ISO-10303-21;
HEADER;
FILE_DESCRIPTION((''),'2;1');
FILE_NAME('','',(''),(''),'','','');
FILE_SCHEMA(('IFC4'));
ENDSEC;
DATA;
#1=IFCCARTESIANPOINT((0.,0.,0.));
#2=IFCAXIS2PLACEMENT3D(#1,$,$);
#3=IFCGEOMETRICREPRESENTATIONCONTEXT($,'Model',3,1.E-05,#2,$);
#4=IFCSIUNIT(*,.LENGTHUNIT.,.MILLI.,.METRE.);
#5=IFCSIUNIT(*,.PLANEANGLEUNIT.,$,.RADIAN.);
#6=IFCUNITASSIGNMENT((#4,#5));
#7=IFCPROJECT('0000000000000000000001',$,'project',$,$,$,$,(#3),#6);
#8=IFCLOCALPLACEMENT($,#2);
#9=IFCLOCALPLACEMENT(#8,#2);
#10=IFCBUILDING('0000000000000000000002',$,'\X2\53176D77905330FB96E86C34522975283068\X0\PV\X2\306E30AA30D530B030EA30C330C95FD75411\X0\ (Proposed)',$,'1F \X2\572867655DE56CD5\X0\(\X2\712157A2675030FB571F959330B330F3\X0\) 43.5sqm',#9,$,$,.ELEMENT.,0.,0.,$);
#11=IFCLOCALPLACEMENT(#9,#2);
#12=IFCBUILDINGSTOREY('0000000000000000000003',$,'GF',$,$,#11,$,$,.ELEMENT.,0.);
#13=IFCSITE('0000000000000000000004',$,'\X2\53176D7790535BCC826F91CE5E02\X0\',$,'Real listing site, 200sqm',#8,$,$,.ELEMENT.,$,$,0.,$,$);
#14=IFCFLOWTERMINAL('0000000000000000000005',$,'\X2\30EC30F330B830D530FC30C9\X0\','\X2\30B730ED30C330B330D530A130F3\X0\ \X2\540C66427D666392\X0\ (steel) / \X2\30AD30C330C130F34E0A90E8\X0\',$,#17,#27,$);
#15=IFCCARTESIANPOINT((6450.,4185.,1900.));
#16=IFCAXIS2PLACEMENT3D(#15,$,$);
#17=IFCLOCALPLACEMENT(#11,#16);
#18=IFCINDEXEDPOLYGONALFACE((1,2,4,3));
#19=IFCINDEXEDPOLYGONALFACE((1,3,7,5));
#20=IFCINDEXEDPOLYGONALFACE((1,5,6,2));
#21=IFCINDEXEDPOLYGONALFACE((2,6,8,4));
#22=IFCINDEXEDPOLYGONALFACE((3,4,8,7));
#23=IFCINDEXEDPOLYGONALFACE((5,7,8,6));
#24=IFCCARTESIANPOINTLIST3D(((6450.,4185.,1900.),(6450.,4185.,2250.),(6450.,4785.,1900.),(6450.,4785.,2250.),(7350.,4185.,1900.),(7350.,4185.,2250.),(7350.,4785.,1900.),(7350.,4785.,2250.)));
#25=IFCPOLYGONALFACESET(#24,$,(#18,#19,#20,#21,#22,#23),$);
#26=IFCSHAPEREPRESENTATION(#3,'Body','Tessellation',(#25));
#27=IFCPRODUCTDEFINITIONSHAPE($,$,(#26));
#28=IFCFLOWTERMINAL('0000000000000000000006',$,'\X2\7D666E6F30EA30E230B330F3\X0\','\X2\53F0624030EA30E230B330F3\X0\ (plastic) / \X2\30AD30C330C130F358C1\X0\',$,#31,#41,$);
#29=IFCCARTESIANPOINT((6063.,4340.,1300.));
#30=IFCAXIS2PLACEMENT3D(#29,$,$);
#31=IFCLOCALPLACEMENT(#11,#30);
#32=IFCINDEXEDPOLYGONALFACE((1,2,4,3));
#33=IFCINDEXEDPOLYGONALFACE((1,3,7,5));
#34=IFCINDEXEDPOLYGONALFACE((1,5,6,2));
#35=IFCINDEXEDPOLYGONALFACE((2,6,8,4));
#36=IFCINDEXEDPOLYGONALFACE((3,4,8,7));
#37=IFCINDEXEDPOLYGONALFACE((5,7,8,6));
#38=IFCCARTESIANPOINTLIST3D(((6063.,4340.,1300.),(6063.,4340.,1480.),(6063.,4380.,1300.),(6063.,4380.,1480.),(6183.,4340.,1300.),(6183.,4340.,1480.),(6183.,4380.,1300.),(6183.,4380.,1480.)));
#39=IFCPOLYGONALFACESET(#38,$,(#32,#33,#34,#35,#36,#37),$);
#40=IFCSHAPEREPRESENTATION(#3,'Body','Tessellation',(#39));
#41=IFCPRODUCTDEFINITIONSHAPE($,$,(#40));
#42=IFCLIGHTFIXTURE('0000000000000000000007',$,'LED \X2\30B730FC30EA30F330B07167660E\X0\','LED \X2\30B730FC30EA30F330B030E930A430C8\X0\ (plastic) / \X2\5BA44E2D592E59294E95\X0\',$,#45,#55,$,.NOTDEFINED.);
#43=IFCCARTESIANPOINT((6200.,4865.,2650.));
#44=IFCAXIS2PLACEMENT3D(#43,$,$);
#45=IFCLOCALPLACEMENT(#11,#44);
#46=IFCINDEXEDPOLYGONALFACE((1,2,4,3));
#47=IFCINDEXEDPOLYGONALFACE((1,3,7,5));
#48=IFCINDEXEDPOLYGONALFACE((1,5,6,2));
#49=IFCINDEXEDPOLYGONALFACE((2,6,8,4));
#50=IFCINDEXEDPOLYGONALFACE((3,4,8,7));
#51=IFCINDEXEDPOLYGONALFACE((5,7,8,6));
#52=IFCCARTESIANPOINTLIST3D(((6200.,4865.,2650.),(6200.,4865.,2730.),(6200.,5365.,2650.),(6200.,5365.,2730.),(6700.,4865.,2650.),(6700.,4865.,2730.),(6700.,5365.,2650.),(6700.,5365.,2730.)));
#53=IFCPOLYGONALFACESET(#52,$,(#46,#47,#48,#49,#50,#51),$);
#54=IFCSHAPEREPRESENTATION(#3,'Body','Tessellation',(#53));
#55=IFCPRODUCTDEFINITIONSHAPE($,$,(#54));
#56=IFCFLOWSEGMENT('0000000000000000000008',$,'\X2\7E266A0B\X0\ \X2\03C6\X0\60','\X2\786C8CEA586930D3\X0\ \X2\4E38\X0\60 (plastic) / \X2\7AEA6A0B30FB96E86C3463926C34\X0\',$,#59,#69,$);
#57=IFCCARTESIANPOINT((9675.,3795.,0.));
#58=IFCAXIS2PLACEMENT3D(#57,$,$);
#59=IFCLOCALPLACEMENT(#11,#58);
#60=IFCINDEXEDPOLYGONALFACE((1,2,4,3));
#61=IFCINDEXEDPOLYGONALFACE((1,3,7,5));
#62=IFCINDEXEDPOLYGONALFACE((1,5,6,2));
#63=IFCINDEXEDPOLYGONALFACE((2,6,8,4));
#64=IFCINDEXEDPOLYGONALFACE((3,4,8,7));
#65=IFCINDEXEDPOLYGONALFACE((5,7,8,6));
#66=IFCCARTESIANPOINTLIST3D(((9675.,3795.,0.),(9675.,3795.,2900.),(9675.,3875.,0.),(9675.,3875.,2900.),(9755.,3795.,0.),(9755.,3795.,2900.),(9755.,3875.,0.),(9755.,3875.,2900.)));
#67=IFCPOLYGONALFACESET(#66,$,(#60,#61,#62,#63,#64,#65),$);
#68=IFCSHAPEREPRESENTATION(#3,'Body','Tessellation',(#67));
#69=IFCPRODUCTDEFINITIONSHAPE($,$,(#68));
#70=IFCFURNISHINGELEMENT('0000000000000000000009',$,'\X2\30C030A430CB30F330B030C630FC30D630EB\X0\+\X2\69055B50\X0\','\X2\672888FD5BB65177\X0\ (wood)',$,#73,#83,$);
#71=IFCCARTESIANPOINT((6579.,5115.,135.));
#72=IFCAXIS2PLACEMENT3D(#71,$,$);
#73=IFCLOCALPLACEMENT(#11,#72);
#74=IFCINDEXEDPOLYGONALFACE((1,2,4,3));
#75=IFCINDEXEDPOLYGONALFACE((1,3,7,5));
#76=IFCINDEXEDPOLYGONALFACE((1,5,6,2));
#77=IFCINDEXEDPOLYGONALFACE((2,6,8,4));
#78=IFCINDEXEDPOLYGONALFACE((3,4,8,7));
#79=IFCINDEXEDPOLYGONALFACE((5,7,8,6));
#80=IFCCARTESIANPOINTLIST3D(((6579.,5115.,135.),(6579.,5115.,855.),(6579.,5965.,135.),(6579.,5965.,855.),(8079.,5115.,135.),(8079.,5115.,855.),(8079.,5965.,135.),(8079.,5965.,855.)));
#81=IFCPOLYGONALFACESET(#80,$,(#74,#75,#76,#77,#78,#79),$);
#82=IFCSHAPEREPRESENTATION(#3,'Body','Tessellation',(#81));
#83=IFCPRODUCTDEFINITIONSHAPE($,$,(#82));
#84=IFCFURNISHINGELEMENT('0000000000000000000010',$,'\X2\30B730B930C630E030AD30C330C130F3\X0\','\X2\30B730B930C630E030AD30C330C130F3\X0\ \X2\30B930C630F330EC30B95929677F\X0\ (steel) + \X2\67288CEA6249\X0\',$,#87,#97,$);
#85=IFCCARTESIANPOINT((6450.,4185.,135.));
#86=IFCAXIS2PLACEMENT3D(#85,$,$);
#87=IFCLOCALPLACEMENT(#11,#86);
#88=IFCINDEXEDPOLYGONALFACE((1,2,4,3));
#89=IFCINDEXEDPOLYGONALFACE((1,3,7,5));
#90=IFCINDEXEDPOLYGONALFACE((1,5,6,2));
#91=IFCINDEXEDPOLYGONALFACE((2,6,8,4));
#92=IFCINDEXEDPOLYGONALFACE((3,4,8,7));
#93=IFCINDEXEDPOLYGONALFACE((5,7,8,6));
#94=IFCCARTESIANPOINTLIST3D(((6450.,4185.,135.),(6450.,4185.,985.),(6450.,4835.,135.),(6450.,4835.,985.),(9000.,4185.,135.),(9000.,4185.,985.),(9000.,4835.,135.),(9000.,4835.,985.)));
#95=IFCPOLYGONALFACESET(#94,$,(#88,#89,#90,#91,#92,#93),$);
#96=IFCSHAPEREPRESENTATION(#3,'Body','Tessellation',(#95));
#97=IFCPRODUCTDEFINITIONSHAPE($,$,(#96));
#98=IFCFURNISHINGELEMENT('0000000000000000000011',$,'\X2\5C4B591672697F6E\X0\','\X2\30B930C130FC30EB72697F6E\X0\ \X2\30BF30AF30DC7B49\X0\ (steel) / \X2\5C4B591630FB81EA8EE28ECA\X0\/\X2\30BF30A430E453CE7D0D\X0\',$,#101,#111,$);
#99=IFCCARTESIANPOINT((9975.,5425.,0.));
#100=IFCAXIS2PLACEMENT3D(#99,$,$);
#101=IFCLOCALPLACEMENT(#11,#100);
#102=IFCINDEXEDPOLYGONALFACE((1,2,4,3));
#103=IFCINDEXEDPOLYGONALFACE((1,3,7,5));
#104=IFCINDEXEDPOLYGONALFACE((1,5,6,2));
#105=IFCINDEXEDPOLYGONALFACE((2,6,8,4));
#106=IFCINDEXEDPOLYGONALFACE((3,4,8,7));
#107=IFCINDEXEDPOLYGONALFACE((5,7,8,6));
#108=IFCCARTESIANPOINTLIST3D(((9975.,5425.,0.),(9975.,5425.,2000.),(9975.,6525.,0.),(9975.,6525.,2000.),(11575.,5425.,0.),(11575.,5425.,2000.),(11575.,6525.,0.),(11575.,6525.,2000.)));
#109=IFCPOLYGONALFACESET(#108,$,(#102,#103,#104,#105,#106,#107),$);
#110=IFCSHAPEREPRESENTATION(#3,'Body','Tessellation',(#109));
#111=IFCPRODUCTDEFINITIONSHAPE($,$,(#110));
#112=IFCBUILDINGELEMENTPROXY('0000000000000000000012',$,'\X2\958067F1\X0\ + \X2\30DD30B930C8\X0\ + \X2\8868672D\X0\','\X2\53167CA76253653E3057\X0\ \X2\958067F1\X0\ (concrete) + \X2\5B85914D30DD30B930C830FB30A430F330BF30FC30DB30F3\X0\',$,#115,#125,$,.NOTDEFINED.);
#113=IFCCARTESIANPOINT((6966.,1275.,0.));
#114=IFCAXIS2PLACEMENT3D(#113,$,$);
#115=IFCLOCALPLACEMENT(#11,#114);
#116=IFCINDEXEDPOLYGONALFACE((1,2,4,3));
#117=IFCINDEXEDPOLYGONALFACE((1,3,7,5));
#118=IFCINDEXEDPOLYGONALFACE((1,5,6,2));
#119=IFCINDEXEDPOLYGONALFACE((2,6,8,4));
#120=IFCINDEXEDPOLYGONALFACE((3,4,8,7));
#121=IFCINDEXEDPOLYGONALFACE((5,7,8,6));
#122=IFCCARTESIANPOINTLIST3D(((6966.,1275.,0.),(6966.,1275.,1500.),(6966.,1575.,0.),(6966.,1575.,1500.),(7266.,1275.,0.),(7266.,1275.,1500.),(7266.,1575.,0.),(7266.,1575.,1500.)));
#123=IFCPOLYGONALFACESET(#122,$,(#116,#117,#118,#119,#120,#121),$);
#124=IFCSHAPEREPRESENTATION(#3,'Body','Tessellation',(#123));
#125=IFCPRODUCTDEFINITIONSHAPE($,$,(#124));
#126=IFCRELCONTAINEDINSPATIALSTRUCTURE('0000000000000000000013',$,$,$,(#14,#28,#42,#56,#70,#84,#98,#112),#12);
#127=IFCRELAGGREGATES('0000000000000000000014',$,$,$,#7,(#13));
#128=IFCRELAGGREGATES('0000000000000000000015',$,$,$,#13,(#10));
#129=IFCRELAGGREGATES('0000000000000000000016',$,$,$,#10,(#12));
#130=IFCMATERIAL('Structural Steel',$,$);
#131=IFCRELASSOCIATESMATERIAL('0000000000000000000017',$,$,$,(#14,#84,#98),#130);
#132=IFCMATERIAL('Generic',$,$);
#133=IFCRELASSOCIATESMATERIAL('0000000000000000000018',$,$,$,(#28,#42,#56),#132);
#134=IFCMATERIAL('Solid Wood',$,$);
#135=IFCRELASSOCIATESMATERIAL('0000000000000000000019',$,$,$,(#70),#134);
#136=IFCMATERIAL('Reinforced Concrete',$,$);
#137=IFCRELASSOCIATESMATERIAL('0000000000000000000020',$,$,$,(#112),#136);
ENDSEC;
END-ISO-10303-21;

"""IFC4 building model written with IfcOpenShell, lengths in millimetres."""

from ifc_helpers import new_model, si_unit, frame, frame_2d, origin, place, context, project, spatial, rectangle, extrude, material, element, save


model = new_model("IFC4")

# Units and contexts
model_context = context("Model", 3, precision=1e-05, world=origin())
ifc_project = project(units=[si_unit("LENGTHUNIT", "METRE", prefix="MILLI"), si_unit("PLANEANGLEUNIT", "RADIAN")], contexts=[model_context])

# Site, building, storey
site_placement = place(None, origin())
site = spatial("IfcSite", under=ifc_project, at=site_placement, Name="北海道富良野市", ObjectType="Real listing site, 200sqm", CompositionType="ELEMENT", RefElevation=0.0)
building_placement = place(site_placement, origin())
building = spatial("IfcBuilding", under=site, at=building_placement, Name="北海道・雨水利用とPVのオフグリッド志向 (Proposed)", ObjectType="1F 在来工法(無垢材・土間コン) 43.5sqm", CompositionType="ELEMENT", ElevationOfRefHeight=0.0, ElevationOfTerrain=0.0)
storey_placement = place(building_placement, origin())
storey = spatial("IfcBuildingStorey", under=building, at=storey_placement, Name="GF", CompositionType="ELEMENT", Elevation=0.0)

# Shared definitions
ifc_material_1 = material(Name="Solid Wood")

# Shared definitions
ifc_material_2 = material(Name="Structural Steel")

# Shared definitions
ifc_material_3 = material(Name="Reinforced Concrete")

# Flow terminals
flow_terminal_1_placement = place(storey_placement, frame((6450.0, 4185.0, 1900.0)))
element("IfcFlowTerminal", 1, at=flow_terminal_1_placement, inside=storey, material=ifc_material_2, Name="レンジフード", Description="シロッコファン 同時給排 (steel) / キッチン上部", context=model_context, shape_type="SweptSolid", body=[
    extrude(rectangle(XDim=900.0, YDim=600.0, at=frame_2d((450.0, 300.0))), frame((6450.0, 4185.0, 1900.0)), (0.0, 0.0, 1.0), 350.0),
])
ifc_material_4 = material(Name="Generic")
flow_terminal_2_placement = place(storey_placement, frame((6063.0, 4340.0, 1300.0)))
element("IfcFlowTerminal", 2, at=flow_terminal_2_placement, inside=storey, material=ifc_material_4, Name="給湯リモコン", Description="台所リモコン (plastic) / キッチン壁", context=model_context, shape_type="SweptSolid", body=[
    extrude(rectangle(XDim=120.0, YDim=40.0, at=frame_2d((60.0, 20.0))), frame((6063.0, 4340.0, 1300.0)), (0.0, 0.0, 1.0), 180.0),
])

# Light fixture
light_fixture_placement = place(storey_placement, frame((6200.0, 4865.0, 2650.0)))
element("IfcLightFixture", 3, at=light_fixture_placement, inside=storey, material=ifc_material_4, Name="LED シーリング照明", Description="LED シーリングライト (plastic) / 室中央天井", PredefinedType="NOTDEFINED", context=model_context, shape_type="SweptSolid", body=[
    extrude(rectangle(XDim=500.0, YDim=500.0, at=frame_2d((250.0, 250.0))), frame((6200.0, 4865.0, 2650.0)), (0.0, 0.0, 1.0), 80.0),
])

# Flow segment
flow_segment_placement = place(storey_placement, frame((9675.0, 3795.0, 0.0)))
element("IfcFlowSegment", 4, at=flow_segment_placement, inside=storey, material=ifc_material_4, Name="縦樋 φ60", Description="硬質塩ビ 丸60 (plastic) / 竪樋・雨水排水", context=model_context, shape_type="SweptSolid", body=[
    extrude(rectangle(XDim=80.0, YDim=80.0, at=frame_2d((40.0, 40.0))), frame((9675.0, 3795.0, 0.0)), (0.0, 0.0, 1.0), 2900.0),
])

# Furnishing elements
furnishing_1_placement = place(storey_placement, frame((6579.0, 5115.0, 135.0)))
element("IfcFurnishingElement", 5, at=furnishing_1_placement, inside=storey, material=ifc_material_1, Name="ダイニングテーブル+椅子", Description="木製家具 (wood)", context=model_context, shape_type="SweptSolid", body=[
    extrude(rectangle(XDim=1500.0, YDim=850.0, at=frame_2d((750.0, 425.0))), frame((6579.0, 5115.0, 135.0)), (0.0, 0.0, 1.0), 720.0),
])
furnishing_2_placement = place(storey_placement, frame((6450.0, 4185.0, 135.0)))
element("IfcFurnishingElement", 6, at=furnishing_2_placement, inside=storey, material=ifc_material_2, Name="システムキッチン", Description="システムキッチン ステンレス天板 (steel) + 木質扉", context=model_context, shape_type="SweptSolid", body=[
    extrude(rectangle(XDim=2550.0, YDim=650.0, at=frame_2d((1275.0, 325.0))), frame((6450.0, 4185.0, 135.0)), (0.0, 0.0, 1.0), 850.0),
])
furnishing_3_placement = place(storey_placement, frame((9975.0, 5425.0, 0.0)))
element("IfcFurnishingElement", 7, at=furnishing_3_placement, inside=storey, material=ifc_material_2, Name="屋外物置", Description="スチール物置 タクボ等 (steel) / 屋外・自転車/タイヤ収納", context=model_context, shape_type="SweptSolid", body=[
    extrude(rectangle(XDim=1600.0, YDim=1100.0, at=frame_2d((800.0, 550.0))), frame((9975.0, 5425.0, 0.0)), (0.0, 0.0, 1.0), 2000.0),
])

# Building element proxy
proxy_placement = place(storey_placement, frame((6966.0, 1275.0, 0.0)))
element("IfcBuildingElementProxy", 8, at=proxy_placement, inside=storey, material=ifc_material_3, Name="門柱 + ポスト + 表札", Description="化粧打放し 門柱 (concrete) + 宅配ポスト・インターホン", PredefinedType="NOTDEFINED", context=model_context, shape_type="SweptSolid", body=[
    extrude(rectangle(XDim=300.0, YDim=300.0, at=frame_2d((150.0, 150.0))), frame((6966.0, 1275.0, 0.0)), (0.0, 0.0, 1.0), 1500.0),
])

save(model, "model.ifc")
